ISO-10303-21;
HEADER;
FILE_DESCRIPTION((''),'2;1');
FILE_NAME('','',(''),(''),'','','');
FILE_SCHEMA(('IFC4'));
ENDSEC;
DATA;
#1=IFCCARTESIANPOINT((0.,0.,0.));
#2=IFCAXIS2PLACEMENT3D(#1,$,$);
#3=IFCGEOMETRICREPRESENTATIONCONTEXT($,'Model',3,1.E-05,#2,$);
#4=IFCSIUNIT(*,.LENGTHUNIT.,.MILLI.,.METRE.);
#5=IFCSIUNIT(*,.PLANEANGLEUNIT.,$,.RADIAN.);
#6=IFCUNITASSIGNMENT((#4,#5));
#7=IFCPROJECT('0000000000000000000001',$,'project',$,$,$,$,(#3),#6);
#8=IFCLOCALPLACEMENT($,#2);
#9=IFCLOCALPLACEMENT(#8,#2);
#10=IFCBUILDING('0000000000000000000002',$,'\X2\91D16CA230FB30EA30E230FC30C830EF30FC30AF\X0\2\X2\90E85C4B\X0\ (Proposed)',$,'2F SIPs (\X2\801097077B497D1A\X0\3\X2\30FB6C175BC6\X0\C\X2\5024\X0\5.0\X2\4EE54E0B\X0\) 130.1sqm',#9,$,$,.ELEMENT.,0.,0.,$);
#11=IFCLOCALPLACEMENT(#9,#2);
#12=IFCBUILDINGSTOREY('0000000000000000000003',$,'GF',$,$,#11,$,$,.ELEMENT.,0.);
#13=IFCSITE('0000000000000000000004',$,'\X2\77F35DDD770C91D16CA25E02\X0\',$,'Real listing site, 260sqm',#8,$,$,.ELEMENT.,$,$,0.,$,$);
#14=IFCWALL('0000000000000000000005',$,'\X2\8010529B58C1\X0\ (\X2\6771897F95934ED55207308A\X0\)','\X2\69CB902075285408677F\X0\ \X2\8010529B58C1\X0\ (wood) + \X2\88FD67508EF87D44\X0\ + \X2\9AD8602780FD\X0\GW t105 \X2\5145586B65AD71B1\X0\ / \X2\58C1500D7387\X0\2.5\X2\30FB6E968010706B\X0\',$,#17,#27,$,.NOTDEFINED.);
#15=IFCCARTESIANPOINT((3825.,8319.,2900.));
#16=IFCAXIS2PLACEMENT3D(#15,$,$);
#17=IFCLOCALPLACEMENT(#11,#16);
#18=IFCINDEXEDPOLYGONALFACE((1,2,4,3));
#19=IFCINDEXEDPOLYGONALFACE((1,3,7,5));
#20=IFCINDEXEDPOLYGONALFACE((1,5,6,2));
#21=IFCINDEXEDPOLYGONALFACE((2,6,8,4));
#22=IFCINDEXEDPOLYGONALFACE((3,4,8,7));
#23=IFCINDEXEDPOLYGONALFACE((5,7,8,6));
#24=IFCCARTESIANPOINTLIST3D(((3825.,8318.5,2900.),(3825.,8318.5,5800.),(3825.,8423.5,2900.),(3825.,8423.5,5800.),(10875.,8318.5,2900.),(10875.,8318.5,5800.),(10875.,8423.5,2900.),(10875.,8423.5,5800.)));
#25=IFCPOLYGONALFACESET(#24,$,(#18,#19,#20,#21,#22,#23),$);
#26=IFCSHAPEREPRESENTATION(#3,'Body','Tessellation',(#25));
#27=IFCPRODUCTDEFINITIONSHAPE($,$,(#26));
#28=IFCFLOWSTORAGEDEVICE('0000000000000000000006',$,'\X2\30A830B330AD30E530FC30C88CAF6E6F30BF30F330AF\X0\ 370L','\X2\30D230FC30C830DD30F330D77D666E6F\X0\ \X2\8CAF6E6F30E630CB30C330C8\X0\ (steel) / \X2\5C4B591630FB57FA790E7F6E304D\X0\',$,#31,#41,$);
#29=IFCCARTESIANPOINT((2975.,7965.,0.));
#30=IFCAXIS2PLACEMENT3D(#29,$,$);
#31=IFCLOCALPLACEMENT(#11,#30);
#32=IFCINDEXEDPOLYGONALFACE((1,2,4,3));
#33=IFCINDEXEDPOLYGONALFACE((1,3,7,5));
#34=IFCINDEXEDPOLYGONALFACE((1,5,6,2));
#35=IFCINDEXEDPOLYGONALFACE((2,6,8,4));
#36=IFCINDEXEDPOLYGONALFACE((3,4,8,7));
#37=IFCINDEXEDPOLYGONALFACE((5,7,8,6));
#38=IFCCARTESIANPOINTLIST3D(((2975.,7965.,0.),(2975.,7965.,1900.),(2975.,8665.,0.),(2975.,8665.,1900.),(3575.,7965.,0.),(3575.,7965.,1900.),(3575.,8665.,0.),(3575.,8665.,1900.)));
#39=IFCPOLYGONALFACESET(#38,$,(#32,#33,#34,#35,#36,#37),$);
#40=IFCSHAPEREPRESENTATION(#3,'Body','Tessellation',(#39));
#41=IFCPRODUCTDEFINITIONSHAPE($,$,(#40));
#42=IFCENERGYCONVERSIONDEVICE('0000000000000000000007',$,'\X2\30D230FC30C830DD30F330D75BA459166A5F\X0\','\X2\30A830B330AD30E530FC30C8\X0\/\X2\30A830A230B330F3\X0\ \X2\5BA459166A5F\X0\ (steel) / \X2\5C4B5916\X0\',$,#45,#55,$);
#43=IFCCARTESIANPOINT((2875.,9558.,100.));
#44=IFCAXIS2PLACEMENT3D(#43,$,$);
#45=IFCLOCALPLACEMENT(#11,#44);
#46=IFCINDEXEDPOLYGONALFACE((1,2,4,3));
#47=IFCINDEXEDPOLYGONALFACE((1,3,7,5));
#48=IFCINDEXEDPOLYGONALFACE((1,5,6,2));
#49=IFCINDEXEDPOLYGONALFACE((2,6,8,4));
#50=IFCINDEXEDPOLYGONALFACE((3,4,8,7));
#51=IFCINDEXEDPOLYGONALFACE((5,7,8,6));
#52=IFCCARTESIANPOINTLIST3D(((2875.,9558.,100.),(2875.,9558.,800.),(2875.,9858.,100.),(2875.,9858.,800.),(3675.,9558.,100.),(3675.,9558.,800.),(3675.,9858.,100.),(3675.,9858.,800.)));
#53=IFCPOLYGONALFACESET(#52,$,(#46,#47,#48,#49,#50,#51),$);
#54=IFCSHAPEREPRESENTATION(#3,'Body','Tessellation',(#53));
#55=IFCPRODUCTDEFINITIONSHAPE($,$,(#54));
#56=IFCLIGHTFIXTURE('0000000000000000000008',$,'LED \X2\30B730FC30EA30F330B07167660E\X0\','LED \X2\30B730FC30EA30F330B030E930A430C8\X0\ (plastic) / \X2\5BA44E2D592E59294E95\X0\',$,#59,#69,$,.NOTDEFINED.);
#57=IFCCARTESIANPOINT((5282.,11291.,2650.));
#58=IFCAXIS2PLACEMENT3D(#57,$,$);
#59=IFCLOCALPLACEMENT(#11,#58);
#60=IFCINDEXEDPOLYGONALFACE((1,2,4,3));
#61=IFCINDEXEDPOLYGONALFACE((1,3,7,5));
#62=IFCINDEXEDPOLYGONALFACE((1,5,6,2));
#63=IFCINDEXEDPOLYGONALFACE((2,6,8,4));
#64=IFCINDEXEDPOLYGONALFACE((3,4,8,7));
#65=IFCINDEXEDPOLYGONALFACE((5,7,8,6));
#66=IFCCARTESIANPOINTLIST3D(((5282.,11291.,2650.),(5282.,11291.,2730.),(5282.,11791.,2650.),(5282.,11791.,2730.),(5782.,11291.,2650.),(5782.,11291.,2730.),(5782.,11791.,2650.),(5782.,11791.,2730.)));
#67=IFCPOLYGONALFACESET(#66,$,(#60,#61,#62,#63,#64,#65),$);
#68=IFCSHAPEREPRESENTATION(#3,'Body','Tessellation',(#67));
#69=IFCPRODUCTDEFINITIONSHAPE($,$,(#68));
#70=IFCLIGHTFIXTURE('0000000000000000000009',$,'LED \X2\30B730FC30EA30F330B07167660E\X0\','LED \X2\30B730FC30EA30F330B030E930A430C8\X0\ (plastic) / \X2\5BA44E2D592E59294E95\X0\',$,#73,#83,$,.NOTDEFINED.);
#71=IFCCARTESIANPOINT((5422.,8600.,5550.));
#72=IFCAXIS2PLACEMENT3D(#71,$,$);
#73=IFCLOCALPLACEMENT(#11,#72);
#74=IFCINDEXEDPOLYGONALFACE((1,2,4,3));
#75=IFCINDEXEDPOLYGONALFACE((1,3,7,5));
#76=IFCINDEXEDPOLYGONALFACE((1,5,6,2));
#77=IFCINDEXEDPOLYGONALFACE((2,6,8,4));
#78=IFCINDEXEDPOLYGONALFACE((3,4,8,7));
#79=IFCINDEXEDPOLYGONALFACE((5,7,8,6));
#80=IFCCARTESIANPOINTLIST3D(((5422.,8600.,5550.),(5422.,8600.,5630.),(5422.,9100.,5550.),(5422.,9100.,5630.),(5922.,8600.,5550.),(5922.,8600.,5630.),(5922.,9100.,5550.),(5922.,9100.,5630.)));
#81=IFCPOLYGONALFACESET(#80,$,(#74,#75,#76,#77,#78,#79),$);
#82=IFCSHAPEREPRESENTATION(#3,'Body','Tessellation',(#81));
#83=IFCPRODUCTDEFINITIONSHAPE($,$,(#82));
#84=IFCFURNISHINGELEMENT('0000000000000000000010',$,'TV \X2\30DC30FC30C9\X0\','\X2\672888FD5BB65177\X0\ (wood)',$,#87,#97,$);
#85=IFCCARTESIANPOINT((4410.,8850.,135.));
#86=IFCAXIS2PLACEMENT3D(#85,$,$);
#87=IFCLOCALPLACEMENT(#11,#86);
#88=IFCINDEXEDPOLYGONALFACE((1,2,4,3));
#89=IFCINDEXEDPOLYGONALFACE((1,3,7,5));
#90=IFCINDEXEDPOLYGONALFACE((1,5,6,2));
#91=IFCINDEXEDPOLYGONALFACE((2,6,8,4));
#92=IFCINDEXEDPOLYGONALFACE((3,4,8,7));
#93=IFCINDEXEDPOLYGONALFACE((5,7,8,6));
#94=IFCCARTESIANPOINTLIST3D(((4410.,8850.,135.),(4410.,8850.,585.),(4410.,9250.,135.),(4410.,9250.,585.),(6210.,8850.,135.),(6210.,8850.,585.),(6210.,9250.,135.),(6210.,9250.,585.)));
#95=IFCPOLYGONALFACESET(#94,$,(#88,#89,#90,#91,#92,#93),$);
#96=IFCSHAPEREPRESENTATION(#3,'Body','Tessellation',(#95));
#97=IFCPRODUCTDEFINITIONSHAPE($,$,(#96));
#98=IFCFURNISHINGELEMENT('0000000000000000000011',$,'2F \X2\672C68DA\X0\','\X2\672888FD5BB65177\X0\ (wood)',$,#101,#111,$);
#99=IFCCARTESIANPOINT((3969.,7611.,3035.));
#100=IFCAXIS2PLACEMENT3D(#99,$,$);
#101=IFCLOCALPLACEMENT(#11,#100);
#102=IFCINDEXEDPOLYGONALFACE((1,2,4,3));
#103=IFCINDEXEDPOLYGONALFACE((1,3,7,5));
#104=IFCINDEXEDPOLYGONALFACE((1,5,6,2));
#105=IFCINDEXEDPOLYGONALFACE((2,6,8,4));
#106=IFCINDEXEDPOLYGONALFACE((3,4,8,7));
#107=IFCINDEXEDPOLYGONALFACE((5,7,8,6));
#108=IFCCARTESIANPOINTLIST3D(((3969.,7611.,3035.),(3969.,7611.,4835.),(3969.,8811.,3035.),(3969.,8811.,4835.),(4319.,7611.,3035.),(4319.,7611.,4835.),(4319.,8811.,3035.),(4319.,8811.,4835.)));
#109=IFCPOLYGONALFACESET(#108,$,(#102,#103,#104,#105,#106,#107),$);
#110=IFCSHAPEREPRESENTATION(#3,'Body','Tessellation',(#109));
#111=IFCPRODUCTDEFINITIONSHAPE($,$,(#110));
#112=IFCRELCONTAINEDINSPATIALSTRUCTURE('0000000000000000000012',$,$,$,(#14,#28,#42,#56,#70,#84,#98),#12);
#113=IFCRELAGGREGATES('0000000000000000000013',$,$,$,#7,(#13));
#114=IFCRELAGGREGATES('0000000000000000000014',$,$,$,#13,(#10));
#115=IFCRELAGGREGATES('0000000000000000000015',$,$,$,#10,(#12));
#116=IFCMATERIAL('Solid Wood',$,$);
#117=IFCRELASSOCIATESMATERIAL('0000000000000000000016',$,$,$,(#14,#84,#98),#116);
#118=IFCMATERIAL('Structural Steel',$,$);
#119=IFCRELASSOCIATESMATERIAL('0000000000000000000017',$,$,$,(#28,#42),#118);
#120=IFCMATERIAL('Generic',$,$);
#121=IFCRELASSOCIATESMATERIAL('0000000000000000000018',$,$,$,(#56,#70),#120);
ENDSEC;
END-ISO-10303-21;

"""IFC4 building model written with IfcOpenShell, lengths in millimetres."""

from ifc_helpers import new_model, si_unit, frame, frame_2d, origin, place, context, project, spatial, rectangle, extrude, material, element, save


model = new_model("IFC4")

# Units and contexts
model_context = context("Model", 3, precision=1e-05, world=origin())
ifc_project = project(units=[si_unit("LENGTHUNIT", "METRE", prefix="MILLI"), si_unit("PLANEANGLEUNIT", "RADIAN")], contexts=[model_context])

# Site, building, storey
site_placement = place(None, origin())
site = spatial("IfcSite", under=ifc_project, at=site_placement, Name="石川県金沢市", ObjectType="Real listing site, 260sqm", CompositionType="ELEMENT", RefElevation=0.0)
building_placement = place(site_placement, origin())
building = spatial("IfcBuilding", under=site, at=building_placement, Name="金沢・リモートワーク2部屋 (Proposed)", ObjectType="2F SIPs (耐震等級3・気密C値5.0以下) 130.1sqm", CompositionType="ELEMENT", ElevationOfRefHeight=0.0, ElevationOfTerrain=0.0)
storey_placement = place(building_placement, origin())
storey = spatial("IfcBuildingStorey", under=building, at=storey_placement, Name="GF", CompositionType="ELEMENT", Elevation=0.0)

# Shared definitions
ifc_material_1 = material(Name="Solid Wood")

# Wall
wall_1_placement = place(storey_placement, frame((3825.0, 8319.0, 2900.0)))
element("IfcWall", 1, at=wall_1_placement, inside=storey, material=ifc_material_1, Name="耐力壁 (東西間仕切り)", Description="構造用合板 耐力壁 (wood) + 製材軸組 + 高性能GW t105 充填断熱 / 壁倍率2.5・準耐火", PredefinedType="NOTDEFINED", context=model_context, shape_type="SweptSolid", body=[
    extrude(rectangle(XDim=7050.0, YDim=105.0, at=frame_2d((3525.0, 52.0))), frame((3825.0, 8319.0, 2900.0)), (0.0, 0.0, 1.0), 2900.0),
])

# Flow storage device
ifc_material_2 = material(Name="Structural Steel")
flow_storage_device_placement = place(storey_placement, frame((2975.0, 7965.0, 0.0)))
element("IfcFlowStorageDevice", 2, at=flow_storage_device_placement, inside=storey, material=ifc_material_2, Name="エコキュート貯湯タンク 370L", Description="ヒートポンプ給湯 貯湯ユニット (steel) / 屋外・基礎置き", context=model_context, shape_type="SweptSolid", body=[
    extrude(rectangle(XDim=600.0, YDim=700.0, at=frame_2d((300.0, 350.0))), frame((2975.0, 7965.0, 0.0)), (0.0, 0.0, 1.0), 1900.0),
])

# Energy conversion device
energy_conversion_device_placement = place(storey_placement, frame((2875.0, 9558.0, 100.0)))
element("IfcEnergyConversionDevice", 3, at=energy_conversion_device_placement, inside=storey, material=ifc_material_2, Name="ヒートポンプ室外機", Description="エコキュート/エアコン 室外機 (steel) / 屋外", context=model_context, shape_type="SweptSolid", body=[
    extrude(rectangle(XDim=800.0, YDim=300.0, at=frame_2d((400.0, 150.0))), frame((2875.0, 9558.0, 100.0)), (0.0, 0.0, 1.0), 700.0),
])

# Light fixtures
ifc_material_3 = material(Name="Generic")
light_fixture_1_placement = place(storey_placement, frame((5282.0, 11291.0, 2650.0)))
element("IfcLightFixture", 4, at=light_fixture_1_placement, inside=storey, material=ifc_material_3, Name="LED シーリング照明", Description="LED シーリングライト (plastic) / 室中央天井", PredefinedType="NOTDEFINED", context=model_context, shape_type="SweptSolid", body=[
    extrude(rectangle(XDim=500.0, YDim=500.0, at=frame_2d((250.0, 250.0))), frame((5282.0, 11291.0, 2650.0)), (0.0, 0.0, 1.0), 80.0),
])
light_fixture_2_placement = place(storey_placement, frame((5422.0, 8600.0, 5550.0)))
element("IfcLightFixture", 5, at=light_fixture_2_placement, inside=storey, material=ifc_material_3, Name="LED シーリング照明", Description="LED シーリングライト (plastic) / 室中央天井", PredefinedType="NOTDEFINED", context=model_context, shape_type="SweptSolid", body=[
    extrude(rectangle(XDim=500.0, YDim=500.0, at=frame_2d((250.0, 250.0))), frame((5422.0, 8600.0, 5550.0)), (0.0, 0.0, 1.0), 80.0),
])

# Furnishing elements
furnishing_1_placement = place(storey_placement, frame((4410.0, 8850.0, 135.0)))
element("IfcFurnishingElement", 6, at=furnishing_1_placement, inside=storey, material=ifc_material_1, Name="TV ボード", Description="木製家具 (wood)", context=model_context, shape_type="SweptSolid", body=[
    extrude(rectangle(XDim=1800.0, YDim=400.0, at=frame_2d((900.0, 200.0))), frame((4410.0, 8850.0, 135.0)), (0.0, 0.0, 1.0), 450.0),
])
furnishing_2_placement = place(storey_placement, frame((3969.0, 7611.0, 3035.0)))
element("IfcFurnishingElement", 7, at=furnishing_2_placement, inside=storey, material=ifc_material_1, Name="2F 本棚", Description="木製家具 (wood)", context=model_context, shape_type="SweptSolid", body=[
    extrude(rectangle(XDim=350.0, YDim=1200.0, at=frame_2d((175.0, 600.0))), frame((3969.0, 7611.0, 3035.0)), (0.0, 0.0, 1.0), 1800.0),
])

save(model, "model.ifc")
